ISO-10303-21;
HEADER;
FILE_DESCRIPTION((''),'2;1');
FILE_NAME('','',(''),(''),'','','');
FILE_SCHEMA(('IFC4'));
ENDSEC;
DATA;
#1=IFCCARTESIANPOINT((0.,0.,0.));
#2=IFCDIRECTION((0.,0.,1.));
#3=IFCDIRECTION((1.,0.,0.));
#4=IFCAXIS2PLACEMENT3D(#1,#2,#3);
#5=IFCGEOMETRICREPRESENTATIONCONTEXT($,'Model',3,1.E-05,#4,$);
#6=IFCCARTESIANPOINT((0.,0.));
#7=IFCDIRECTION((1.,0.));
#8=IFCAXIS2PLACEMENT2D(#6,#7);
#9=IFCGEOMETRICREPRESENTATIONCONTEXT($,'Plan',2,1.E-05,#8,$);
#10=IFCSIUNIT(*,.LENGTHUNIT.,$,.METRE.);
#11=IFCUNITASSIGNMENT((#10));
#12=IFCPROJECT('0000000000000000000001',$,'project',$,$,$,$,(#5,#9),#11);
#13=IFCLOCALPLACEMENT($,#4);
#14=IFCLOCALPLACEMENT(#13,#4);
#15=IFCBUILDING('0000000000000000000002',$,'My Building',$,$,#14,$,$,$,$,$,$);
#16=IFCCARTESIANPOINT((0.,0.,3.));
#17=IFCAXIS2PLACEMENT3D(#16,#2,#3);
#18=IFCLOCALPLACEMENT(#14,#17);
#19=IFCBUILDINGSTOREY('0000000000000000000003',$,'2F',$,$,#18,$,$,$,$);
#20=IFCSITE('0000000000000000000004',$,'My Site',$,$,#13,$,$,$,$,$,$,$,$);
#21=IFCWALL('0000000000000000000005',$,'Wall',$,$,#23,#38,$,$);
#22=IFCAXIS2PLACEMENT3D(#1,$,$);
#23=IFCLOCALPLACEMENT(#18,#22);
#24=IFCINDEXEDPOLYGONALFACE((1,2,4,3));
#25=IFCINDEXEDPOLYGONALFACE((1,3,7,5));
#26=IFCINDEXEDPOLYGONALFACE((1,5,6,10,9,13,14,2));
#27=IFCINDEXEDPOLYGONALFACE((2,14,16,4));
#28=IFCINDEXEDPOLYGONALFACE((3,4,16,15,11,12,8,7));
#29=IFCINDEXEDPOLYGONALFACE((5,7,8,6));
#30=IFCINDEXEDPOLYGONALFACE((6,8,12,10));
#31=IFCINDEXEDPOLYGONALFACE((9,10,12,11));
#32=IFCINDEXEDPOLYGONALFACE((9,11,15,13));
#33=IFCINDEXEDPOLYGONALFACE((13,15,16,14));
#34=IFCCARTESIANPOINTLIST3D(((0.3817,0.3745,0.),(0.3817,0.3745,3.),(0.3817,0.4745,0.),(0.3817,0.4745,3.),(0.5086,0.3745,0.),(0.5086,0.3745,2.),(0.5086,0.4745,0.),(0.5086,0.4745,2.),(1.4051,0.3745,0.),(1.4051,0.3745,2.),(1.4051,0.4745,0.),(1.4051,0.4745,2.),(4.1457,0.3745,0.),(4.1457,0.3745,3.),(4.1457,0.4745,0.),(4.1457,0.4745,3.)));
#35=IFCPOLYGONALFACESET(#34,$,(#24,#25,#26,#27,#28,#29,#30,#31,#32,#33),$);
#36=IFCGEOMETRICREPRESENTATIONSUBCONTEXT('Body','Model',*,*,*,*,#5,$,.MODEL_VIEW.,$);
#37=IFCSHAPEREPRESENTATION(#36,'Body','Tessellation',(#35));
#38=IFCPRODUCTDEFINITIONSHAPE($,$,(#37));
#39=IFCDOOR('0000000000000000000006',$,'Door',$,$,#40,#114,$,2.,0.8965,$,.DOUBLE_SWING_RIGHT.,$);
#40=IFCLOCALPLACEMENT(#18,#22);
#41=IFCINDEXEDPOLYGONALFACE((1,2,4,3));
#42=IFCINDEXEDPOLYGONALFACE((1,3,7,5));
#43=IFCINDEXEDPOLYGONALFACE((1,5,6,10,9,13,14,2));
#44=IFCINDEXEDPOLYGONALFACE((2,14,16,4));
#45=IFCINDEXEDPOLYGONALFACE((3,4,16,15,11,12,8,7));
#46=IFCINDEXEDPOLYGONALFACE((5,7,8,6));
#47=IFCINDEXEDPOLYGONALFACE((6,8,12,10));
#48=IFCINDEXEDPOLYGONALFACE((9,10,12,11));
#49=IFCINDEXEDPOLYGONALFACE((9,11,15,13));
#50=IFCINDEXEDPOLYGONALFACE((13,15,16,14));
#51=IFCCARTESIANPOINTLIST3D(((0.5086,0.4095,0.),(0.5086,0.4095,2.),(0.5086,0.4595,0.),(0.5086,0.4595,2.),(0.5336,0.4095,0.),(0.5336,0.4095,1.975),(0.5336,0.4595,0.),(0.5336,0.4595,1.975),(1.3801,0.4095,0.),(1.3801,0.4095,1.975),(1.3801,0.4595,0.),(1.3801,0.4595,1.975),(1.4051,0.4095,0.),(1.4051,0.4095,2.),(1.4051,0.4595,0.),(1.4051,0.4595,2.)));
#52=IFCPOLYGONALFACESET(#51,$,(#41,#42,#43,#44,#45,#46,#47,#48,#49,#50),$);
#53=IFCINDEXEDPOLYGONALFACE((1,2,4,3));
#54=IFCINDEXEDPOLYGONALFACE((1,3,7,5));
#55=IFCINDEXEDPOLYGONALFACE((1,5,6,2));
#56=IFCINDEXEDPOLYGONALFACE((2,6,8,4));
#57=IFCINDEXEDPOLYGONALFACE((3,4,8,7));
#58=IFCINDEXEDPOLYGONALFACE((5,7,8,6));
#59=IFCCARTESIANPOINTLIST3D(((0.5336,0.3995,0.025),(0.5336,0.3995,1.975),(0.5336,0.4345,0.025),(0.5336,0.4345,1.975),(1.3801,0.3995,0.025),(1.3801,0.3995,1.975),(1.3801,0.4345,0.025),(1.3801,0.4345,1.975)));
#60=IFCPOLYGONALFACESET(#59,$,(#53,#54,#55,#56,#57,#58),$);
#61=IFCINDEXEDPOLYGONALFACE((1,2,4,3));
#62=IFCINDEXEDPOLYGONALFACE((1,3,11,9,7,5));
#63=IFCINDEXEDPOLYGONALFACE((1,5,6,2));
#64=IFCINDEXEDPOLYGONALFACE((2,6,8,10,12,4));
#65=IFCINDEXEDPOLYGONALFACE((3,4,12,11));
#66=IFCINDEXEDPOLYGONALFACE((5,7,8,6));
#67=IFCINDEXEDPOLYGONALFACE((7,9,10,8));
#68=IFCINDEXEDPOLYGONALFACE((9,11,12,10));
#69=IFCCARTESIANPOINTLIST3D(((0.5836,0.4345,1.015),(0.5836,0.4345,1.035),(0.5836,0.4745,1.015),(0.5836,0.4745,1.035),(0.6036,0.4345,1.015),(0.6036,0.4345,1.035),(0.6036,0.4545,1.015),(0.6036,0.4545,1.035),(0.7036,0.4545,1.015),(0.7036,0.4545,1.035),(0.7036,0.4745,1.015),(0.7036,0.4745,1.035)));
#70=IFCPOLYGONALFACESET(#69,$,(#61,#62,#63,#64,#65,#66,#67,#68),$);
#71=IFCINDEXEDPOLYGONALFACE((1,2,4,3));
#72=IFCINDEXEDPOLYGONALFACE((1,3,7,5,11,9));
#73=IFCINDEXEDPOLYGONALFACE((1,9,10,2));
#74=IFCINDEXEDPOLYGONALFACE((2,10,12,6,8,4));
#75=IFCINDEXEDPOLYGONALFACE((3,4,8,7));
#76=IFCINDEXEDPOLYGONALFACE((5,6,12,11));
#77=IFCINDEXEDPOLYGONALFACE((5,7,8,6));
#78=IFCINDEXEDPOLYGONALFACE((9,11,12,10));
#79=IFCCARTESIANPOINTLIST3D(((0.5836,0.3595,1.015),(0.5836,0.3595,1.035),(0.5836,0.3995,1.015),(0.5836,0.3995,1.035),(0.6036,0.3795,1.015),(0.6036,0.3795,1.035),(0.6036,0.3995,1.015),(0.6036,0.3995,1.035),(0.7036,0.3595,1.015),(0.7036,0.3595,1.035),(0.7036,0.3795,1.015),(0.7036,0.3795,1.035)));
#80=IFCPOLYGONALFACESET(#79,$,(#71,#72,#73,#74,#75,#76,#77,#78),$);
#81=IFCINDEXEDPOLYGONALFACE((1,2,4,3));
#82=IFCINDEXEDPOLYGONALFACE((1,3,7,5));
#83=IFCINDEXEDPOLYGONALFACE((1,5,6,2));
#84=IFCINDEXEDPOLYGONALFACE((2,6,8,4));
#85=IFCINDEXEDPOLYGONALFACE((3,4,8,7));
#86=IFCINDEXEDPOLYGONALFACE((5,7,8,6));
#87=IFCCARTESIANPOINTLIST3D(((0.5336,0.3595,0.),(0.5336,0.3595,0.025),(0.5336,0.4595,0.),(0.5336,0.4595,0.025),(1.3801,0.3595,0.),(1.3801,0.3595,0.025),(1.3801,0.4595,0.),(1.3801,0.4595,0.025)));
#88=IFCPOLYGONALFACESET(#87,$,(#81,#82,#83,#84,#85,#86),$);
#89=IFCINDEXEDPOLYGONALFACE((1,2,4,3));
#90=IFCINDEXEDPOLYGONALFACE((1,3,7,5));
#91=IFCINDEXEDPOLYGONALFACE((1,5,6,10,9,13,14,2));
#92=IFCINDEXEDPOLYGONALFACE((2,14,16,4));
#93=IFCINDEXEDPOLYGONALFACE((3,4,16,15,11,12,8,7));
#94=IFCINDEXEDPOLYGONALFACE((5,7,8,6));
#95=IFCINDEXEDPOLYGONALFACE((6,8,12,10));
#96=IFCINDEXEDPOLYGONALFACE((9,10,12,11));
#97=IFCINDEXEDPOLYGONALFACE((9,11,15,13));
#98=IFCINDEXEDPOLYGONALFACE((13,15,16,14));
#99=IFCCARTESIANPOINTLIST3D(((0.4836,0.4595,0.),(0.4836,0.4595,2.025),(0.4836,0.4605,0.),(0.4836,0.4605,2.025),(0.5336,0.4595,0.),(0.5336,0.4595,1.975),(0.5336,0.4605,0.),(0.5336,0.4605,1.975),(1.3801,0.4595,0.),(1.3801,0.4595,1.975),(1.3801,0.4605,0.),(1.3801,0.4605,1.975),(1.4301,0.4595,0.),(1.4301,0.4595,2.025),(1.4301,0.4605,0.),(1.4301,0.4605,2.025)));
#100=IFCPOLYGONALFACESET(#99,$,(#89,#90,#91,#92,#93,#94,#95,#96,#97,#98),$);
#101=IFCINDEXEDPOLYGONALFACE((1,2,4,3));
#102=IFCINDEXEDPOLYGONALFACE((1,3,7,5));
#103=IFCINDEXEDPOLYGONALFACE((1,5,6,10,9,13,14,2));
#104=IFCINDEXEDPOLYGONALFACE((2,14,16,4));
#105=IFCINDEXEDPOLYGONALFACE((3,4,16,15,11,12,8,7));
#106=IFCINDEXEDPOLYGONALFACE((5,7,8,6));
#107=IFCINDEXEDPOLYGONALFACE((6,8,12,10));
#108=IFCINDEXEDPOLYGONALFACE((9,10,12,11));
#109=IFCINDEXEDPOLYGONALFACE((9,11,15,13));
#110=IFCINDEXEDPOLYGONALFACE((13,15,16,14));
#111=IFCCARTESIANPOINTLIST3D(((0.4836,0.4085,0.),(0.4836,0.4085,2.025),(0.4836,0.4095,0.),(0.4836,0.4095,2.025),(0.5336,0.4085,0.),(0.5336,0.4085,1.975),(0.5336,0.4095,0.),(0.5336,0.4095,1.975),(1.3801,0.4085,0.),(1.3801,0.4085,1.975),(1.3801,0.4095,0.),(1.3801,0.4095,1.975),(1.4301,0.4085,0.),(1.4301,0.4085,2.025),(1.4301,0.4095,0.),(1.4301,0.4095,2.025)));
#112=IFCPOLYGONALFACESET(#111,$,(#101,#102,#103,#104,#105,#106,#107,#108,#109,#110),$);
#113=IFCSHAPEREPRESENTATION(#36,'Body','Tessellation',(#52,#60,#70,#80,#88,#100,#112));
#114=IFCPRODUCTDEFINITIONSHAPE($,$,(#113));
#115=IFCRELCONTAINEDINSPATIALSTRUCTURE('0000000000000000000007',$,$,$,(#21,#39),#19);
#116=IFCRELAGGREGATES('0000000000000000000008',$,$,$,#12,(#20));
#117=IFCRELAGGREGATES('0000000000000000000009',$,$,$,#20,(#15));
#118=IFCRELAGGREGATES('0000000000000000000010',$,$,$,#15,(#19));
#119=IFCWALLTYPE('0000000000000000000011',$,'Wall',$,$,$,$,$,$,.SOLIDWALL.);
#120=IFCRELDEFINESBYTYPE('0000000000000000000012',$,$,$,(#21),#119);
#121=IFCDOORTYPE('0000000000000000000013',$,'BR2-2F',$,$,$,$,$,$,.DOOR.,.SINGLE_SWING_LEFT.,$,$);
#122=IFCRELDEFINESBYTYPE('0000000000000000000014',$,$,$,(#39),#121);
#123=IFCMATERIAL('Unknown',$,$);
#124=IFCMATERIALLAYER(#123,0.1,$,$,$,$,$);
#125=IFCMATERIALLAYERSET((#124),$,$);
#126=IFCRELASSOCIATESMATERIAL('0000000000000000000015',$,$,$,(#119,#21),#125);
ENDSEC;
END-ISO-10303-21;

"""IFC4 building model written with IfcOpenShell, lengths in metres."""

from ifc_helpers import new_model, entity, si_unit, frame, origin_with_axes, origin_2d_with_axis, place, context, subcontext, project, spatial, line, indexed_curve, outline, extrude, shape, source, transform, mapped, material, layer, layer_set, layer_usage, type_object, type_shapes, element, fill, save


model = new_model("IFC4")

# Units and contexts
model_context = context("Model", 3, precision=1e-05, world=origin_with_axes())
plan_context = context("Plan", 2, precision=1e-05, world=origin_2d_with_axis())
body_context_1 = subcontext(model_context, "Body", "Model", "MODEL_VIEW")
body_context_2 = subcontext(plan_context, "Body", "Plan", "PLAN_VIEW")
ifc_project = project(units=[si_unit("LENGTHUNIT", "METRE")], contexts=[model_context, plan_context])

# Site, building, storey
site_placement = place(None, origin_with_axes())
site = spatial("IfcSite", under=ifc_project, at=site_placement, Name="My Site")
building_placement = place(site_placement, origin_with_axes())
building = spatial("IfcBuilding", under=site, at=building_placement, Name="My Building")
storey_placement = place(building_placement, frame((0.0, 0.0, 3.0), z_axis=(0.0, 0.0, 1.0), x_axis=(1.0, 0.0, 0.0)))
storey = spatial("IfcBuildingStorey", under=building, at=storey_placement, Name="2F")

# Shared definitions
ifc_material = material(Name="Unknown")

# Wall, opening, door
ifc_layer_1 = layer(ifc_material, 0.1)
ifc_layer_set_1 = layer_set([ifc_layer_1])
ifc_layer_usage_1 = layer_usage(ifc_layer_set_1, "AXIS2", "POSITIVE", 0.0)
wall_type_1 = type_object("IfcWallType", Name="Wall", PredefinedType="SOLIDWALL", material=ifc_layer_set_1)
wall_1_placement = place(storey_placement, frame((4.1457, 0.4745, 0.0), z_axis=(0.0, 0.0, 1.0), x_axis=(-1.0, 0.0, 0.0)))
wall_1 = element("IfcWall", 1, at=wall_1_placement, inside=storey, type_object=wall_type_1, material=ifc_layer_usage_1, Name="Wall", context=body_context_1, shape_type="SweptSolid", body=[
    extrude(outline(indexed_curve([(0.0, 0.0), (0.0, 0.1), (3.764, 0.1), (3.764, 0.0)], segments=[line(1, 2, 3, 4, 1)])), origin_with_axes(), (0.0, 0.0, 1.0), 3.0),
])
shared_shape_1 = source(origin_with_axes(), body_context_1, "Body", "SweptSolid", [
    extrude(outline(indexed_curve([(0.0, 0.0), (0.8965, 0.0), (0.8965, 2.0), (0.0, 2.0)], segments=[line(1, 2, 3, 4, 1)])), frame((0.0, -0.6, 0.0), z_axis=(0.0, -1.0, 0.0), x_axis=(1.0, 0.0, 0.0)), (0.0, 0.0, -1.0), 1.2),
])
opening_1_placement = place(wall_1_placement, frame((2.7406, 0.015, 0.0), z_axis=(0.0, 0.0, 1.0), x_axis=(1.0, 0.0, 0.0)))
opening_1 = element("IfcOpeningElement", 2, at=opening_1_placement, cuts=wall_1, PredefinedType="OPENING", context=body_context_1, shape_type="MappedRepresentation", body=[
    mapped(shared_shape_1, transform((0.0, 0.0, 0.0), x_axis=(1.0, 0.0, 0.0), y_axis=(0.0, 1.0, 0.0), z_axis=(0.0, 0.0, 1.0), scale=1.0)),
])
door_type_1 = type_object("IfcDoorType", Name="BR2-2F", OperationType="SINGLE_SWING_LEFT", PredefinedType="DOOR")
shared_shape_2 = source(origin_with_axes(), body_context_1, "Body", "SweptSolid", [
    extrude(outline(indexed_curve([(0.0, 0.0), (0.0, 2.0), (0.8965, 2.0), (0.8965, 0.0), (0.8715, 0.0), (0.8715, 1.975), (0.025, 1.975), (0.025, 0.0)], segments=[line(1, 2, 3, 4, 5, 6, 7, 8, 1)])), frame((0.0, 0.0, 0.0), z_axis=(0.0, -1.0, 0.0), x_axis=(1.0, 0.0, 0.0)), (0.0, 0.0, -1.0), 0.05),
    extrude(outline(indexed_curve([(0.0, 0.0), (0.8465, 0.0), (0.8465, 0.035), (0.0, 0.035)], segments=[line(1, 2, 3, 4, 1)])), frame((0.025, 0.025, 0.025), z_axis=(0.0, 0.0, 1.0), x_axis=(1.0, 0.0, 0.0)), (0.0, 0.0, 1.0), 1.95),
    extrude(outline(indexed_curve([(0.0, 0.0), (0.0, -0.04), (-0.12, -0.04), (-0.12, -0.02), (-0.02, -0.02), (-0.02, 0.0)], segments=[line(1, 2, 3, 4, 5, 6, 1)])), frame((0.8215, 0.025, 1.015), z_axis=(0.0, 0.0, 1.0), x_axis=(1.0, 0.0, 0.0)), (0.0, 0.0, 1.0), 0.02),
    extrude(outline(indexed_curve([(0.0, 0.0), (0.0, 0.04), (-0.12, 0.04), (-0.12, 0.02), (-0.02, 0.02), (-0.02, 0.0)], segments=[line(1, 2, 3, 4, 5, 6, 1)])), frame((0.8215, 0.06, 1.015), z_axis=(0.0, 0.0, 1.0), x_axis=(1.0, 0.0, 0.0)), (0.0, 0.0, 1.0), 0.02),
    extrude(outline(indexed_curve([(0.0, 0.0), (0.8465, 0.0), (0.8465, 0.1), (0.0, 0.1)], segments=[line(1, 2, 3, 4, 1)])), frame((0.025, 0.0, 0.0), z_axis=(0.0, 0.0, 1.0), x_axis=(1.0, 0.0, 0.0)), (0.0, 0.0, 1.0), 0.025),
    extrude(outline(indexed_curve([(0.0, 0.0), (0.0, 2.025), (0.9465, 2.025), (0.9465, 0.0), (0.8965, 0.0), (0.8965, 1.975), (0.05, 1.975), (0.05, 0.0)], segments=[line(1, 2, 3, 4, 5, 6, 7, 8, 1)])), frame((-0.025, -0.001, 0.0), z_axis=(0.0, -1.0, 0.0), x_axis=(1.0, 0.0, 0.0)), (0.0, 0.0, -1.0), 0.001),
    extrude(outline(indexed_curve([(0.0, 0.0), (0.0, 2.025), (0.9465, 2.025), (0.9465, 0.0), (0.8965, 0.0), (0.8965, 1.975), (0.05, 1.975), (0.05, 0.0)], segments=[line(1, 2, 3, 4, 5, 6, 7, 8, 1)])), frame((-0.025, 0.05, 0.0), z_axis=(0.0, -1.0, 0.0), x_axis=(1.0, 0.0, 0.0)), (0.0, 0.0, -1.0), 0.001),
])
shared_shape_3 = source(origin_with_axes(), body_context_2, "Body", "Curve2D", [
    entity("IfcIndexedPolyCurve", entity("IfcCartesianPointList2D", [[0.0, 0.0], [0.025, 0.0], [0.025, 0.05], [0.0, 0.05]]), [entity("IfcLineIndex", [1, 2, 3, 4, 1])]),
    entity("IfcIndexedPolyCurve", entity("IfcCartesianPointList2D", [[0.8965, 0.0], [0.8715, 0.0], [0.8715, 0.05], [0.8965, 0.05]]), [entity("IfcLineIndex", [1, 2, 3, 4, 1])]),
    entity("IfcIndexedPolyCurve", entity("IfcCartesianPointList2D", [[0.025, 0.05], [0.025, -0.7965], [0.06, -0.7965]])),
    entity("IfcTrimmedCurve", entity("IfcEllipse", entity("IfcAxis2Placement2D", entity("IfcCartesianPoint", [0.06, 0.05]), entity("IfcDirection", [1.0, 0.0])), 0.8115, 0.8465), [entity("IfcCartesianPoint", [0.06, -0.7965])], [entity("IfcCartesianPoint", [0.06, 0.8965])], True, "CARTESIAN"),
    entity("IfcIndexedPolyCurve", entity("IfcCartesianPointList2D", [[0.025, 0.05], [0.06, 0.05], [0.06, 0.8965], [0.025, 0.8965]]), [entity("IfcLineIndex", [1, 2, 3, 4, 1])]),
])
type_shapes(door_type_1, [shared_shape_2, shared_shape_3])
door_1_placement = place(opening_1_placement, frame((0.0, 0.0, 0.0), z_axis=(0.0, 0.0, 1.0), x_axis=(1.0, 0.0, 0.0)))
door_1 = element("IfcDoor", 3, at=door_1_placement, inside=storey, type_object=door_type_1, Name="Door", OperationType="DOUBLE_SWING_RIGHT", OverallHeight=2.0, OverallWidth=0.8965, shapes=[
    shape(body_context_1, "Body", "MappedRepresentation", [mapped(shared_shape_2, transform((0.0, 0.0, 0.0), x_axis=(1.0, 0.0, 0.0), y_axis=(0.0, 1.0, 0.0), z_axis=(0.0, 0.0, 1.0), scale=1.0))]),
    shape(body_context_2, "Body", "MappedRepresentation", [mapped(shared_shape_3, transform((0.0, 0.0, 0.0), x_axis=(1.0, 0.0, 0.0), y_axis=(0.0, 1.0, 0.0), z_axis=(0.0, 0.0, 1.0), scale=1.0))]),
])
fill(opening_1, door_1)

save(model, "model.ifc")
